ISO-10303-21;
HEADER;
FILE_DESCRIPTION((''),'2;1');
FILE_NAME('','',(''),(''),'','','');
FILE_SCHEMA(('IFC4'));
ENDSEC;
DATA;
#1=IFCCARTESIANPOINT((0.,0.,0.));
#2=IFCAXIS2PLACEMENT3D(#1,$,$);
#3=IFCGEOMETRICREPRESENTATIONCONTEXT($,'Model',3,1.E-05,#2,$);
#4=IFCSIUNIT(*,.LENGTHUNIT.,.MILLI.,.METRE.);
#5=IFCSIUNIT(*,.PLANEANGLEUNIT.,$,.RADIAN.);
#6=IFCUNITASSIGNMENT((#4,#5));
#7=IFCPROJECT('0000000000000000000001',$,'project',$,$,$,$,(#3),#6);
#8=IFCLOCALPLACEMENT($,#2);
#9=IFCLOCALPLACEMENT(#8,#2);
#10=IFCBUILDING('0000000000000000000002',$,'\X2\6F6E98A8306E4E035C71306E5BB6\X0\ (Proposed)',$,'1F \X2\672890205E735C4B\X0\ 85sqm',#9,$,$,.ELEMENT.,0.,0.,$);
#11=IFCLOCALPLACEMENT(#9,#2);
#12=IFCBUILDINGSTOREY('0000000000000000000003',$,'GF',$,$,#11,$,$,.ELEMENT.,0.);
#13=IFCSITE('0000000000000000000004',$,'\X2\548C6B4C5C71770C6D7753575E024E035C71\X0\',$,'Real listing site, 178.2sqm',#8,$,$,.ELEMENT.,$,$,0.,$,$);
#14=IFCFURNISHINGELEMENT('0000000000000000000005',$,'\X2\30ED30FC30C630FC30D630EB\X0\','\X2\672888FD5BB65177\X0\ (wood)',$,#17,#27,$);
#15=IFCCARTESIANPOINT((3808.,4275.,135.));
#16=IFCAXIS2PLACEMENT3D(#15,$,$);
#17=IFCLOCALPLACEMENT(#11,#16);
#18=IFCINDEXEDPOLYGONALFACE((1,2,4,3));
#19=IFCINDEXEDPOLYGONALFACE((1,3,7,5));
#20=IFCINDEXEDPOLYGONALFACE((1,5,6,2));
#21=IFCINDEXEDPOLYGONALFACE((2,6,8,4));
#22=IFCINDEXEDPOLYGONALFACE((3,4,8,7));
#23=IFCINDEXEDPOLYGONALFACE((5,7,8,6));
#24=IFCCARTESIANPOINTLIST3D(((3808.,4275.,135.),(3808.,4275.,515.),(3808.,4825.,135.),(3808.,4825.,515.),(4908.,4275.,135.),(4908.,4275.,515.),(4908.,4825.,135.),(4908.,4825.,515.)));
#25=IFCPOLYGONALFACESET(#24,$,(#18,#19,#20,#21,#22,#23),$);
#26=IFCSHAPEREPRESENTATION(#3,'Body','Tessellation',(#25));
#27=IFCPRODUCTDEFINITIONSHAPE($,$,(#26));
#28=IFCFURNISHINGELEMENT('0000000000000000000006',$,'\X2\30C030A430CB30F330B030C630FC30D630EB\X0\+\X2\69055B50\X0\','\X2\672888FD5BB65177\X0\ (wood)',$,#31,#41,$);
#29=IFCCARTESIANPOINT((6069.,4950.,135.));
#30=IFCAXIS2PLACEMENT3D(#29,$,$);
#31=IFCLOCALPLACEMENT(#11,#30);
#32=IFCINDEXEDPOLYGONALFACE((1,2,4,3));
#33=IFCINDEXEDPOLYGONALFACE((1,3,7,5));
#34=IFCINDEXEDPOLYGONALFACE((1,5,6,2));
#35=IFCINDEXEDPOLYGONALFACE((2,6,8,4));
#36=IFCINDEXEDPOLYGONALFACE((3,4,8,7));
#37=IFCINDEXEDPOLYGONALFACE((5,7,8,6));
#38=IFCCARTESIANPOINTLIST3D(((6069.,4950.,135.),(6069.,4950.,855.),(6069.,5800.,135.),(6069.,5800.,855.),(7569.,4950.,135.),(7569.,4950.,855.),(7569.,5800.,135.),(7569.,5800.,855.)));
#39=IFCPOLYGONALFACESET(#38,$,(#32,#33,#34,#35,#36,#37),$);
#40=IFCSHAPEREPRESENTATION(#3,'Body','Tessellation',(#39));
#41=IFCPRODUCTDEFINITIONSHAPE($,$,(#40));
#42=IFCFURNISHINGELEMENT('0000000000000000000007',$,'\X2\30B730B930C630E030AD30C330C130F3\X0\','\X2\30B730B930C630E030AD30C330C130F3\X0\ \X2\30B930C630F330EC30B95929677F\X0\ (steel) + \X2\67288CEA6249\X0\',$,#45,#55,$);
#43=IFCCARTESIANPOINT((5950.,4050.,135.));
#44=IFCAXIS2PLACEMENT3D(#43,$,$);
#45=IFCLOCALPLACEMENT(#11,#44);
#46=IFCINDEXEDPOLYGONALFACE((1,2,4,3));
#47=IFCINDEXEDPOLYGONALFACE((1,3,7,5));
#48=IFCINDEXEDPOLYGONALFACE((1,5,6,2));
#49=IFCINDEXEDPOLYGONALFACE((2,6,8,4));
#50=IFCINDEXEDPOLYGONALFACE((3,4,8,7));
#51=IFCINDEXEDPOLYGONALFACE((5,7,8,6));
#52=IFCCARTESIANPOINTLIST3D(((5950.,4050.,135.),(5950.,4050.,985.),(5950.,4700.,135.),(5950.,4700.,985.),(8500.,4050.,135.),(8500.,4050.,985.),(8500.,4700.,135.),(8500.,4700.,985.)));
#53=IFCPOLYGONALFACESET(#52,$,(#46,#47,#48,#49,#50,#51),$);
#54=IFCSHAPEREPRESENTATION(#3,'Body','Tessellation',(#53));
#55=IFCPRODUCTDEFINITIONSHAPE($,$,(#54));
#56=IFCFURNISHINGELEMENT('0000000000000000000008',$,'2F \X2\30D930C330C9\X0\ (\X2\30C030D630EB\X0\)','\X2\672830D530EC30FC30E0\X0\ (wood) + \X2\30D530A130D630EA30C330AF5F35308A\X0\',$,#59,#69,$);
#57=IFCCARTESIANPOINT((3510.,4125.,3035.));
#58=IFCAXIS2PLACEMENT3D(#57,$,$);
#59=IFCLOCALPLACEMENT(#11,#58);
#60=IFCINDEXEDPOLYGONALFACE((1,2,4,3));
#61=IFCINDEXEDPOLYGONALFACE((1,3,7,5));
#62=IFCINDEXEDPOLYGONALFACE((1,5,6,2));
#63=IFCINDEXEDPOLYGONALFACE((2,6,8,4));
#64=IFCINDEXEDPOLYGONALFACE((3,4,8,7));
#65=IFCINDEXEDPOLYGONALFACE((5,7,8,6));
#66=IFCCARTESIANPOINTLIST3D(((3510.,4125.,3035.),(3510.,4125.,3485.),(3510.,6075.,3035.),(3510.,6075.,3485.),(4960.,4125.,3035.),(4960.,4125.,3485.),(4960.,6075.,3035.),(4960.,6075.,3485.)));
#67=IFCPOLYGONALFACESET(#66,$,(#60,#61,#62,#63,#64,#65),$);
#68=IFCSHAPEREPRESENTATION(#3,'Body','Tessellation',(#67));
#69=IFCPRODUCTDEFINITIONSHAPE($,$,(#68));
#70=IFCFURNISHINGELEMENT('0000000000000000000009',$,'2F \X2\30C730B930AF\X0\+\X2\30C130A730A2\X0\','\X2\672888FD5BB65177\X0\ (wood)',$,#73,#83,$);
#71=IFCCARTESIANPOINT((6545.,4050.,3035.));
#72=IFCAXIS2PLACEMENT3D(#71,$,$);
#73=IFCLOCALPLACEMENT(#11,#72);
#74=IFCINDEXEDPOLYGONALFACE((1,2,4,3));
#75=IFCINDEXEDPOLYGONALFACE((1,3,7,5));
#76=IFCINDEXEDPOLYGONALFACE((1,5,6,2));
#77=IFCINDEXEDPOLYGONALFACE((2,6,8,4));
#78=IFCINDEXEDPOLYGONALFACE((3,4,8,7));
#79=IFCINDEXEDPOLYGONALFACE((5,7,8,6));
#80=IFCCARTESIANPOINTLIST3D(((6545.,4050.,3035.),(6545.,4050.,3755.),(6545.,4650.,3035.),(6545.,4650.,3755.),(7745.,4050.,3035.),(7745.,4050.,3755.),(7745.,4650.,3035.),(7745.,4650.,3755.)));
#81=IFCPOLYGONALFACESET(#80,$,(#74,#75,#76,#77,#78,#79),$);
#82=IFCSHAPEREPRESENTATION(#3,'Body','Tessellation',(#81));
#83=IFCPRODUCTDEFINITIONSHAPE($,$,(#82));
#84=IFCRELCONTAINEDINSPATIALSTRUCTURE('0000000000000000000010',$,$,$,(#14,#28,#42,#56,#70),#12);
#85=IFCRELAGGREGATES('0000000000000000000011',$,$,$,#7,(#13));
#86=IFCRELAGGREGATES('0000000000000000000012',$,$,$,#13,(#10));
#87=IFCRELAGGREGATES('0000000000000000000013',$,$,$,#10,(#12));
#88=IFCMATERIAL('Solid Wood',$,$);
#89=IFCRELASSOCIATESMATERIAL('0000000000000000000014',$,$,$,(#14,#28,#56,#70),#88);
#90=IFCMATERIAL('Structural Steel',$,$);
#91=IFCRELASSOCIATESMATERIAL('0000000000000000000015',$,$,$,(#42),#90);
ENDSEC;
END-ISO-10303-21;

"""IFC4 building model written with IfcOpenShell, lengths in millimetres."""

from ifc_helpers import new_model, si_unit, frame, frame_2d, origin, place, context, project, spatial, rectangle, extrude, material, element, save


model = new_model("IFC4")

# Units and contexts
model_context = context("Model", 3, precision=1e-05, world=origin())
ifc_project = project(units=[si_unit("LENGTHUNIT", "METRE", prefix="MILLI"), si_unit("PLANEANGLEUNIT", "RADIAN")], contexts=[model_context])

# Site, building, storey
site_placement = place(None, origin())
site = spatial("IfcSite", under=ifc_project, at=site_placement, Name="和歌山県海南市七山", ObjectType="Real listing site, 178.2sqm", CompositionType="ELEMENT", RefElevation=0.0)
building_placement = place(site_placement, origin())
building = spatial("IfcBuilding", under=site, at=building_placement, Name="潮風の七山の家 (Proposed)", ObjectType="1F 木造平屋 85sqm", CompositionType="ELEMENT", ElevationOfRefHeight=0.0, ElevationOfTerrain=0.0)
storey_placement = place(building_placement, origin())
storey = spatial("IfcBuildingStorey", under=building, at=storey_placement, Name="GF", CompositionType="ELEMENT", Elevation=0.0)

# Shared definitions
ifc_material_1 = material(Name="Solid Wood")

# Shared definitions
ifc_material_2 = material(Name="Structural Steel")

# Furnishing elements
furnishing_1_placement = place(storey_placement, frame((3808.0, 4275.0, 135.0)))
element("IfcFurnishingElement", 1, at=furnishing_1_placement, inside=storey, material=ifc_material_1, Name="ローテーブル", Description="木製家具 (wood)", context=model_context, shape_type="SweptSolid", body=[
    extrude(rectangle(XDim=1100.0, YDim=550.0, at=frame_2d((550.0, 275.0))), frame((3808.0, 4275.0, 135.0)), (0.0, 0.0, 1.0), 380.0),
])
furnishing_2_placement = place(storey_placement, frame((6069.0, 4950.0, 135.0)))
element("IfcFurnishingElement", 2, at=furnishing_2_placement, inside=storey, material=ifc_material_1, Name="ダイニングテーブル+椅子", Description="木製家具 (wood)", context=model_context, shape_type="SweptSolid", body=[
    extrude(rectangle(XDim=1500.0, YDim=850.0, at=frame_2d((750.0, 425.0))), frame((6069.0, 4950.0, 135.0)), (0.0, 0.0, 1.0), 720.0),
])
furnishing_3_placement = place(storey_placement, frame((5950.0, 4050.0, 135.0)))
element("IfcFurnishingElement", 3, at=furnishing_3_placement, inside=storey, material=ifc_material_2, Name="システムキッチン", Description="システムキッチン ステンレス天板 (steel) + 木質扉", context=model_context, shape_type="SweptSolid", body=[
    extrude(rectangle(XDim=2550.0, YDim=650.0, at=frame_2d((1275.0, 325.0))), frame((5950.0, 4050.0, 135.0)), (0.0, 0.0, 1.0), 850.0),
])
furnishing_4_placement = place(storey_placement, frame((3510.0, 4125.0, 3035.0)))
element("IfcFurnishingElement", 4, at=furnishing_4_placement, inside=storey, material=ifc_material_1, Name="2F ベッド (ダブル)", Description="木フレーム (wood) + ファブリック張り", context=model_context, shape_type="SweptSolid", body=[
    extrude(rectangle(XDim=1450.0, YDim=1950.0, at=frame_2d((725.0, 975.0))), frame((3510.0, 4125.0, 3035.0)), (0.0, 0.0, 1.0), 450.0),
])
furnishing_5_placement = place(storey_placement, frame((6545.0, 4050.0, 3035.0)))
element("IfcFurnishingElement", 5, at=furnishing_5_placement, inside=storey, material=ifc_material_1, Name="2F デスク+チェア", Description="木製家具 (wood)", context=model_context, shape_type="SweptSolid", body=[
    extrude(rectangle(XDim=1200.0, YDim=600.0, at=frame_2d((600.0, 300.0))), frame((6545.0, 4050.0, 3035.0)), (0.0, 0.0, 1.0), 720.0),
])

save(model, "model.ifc")
